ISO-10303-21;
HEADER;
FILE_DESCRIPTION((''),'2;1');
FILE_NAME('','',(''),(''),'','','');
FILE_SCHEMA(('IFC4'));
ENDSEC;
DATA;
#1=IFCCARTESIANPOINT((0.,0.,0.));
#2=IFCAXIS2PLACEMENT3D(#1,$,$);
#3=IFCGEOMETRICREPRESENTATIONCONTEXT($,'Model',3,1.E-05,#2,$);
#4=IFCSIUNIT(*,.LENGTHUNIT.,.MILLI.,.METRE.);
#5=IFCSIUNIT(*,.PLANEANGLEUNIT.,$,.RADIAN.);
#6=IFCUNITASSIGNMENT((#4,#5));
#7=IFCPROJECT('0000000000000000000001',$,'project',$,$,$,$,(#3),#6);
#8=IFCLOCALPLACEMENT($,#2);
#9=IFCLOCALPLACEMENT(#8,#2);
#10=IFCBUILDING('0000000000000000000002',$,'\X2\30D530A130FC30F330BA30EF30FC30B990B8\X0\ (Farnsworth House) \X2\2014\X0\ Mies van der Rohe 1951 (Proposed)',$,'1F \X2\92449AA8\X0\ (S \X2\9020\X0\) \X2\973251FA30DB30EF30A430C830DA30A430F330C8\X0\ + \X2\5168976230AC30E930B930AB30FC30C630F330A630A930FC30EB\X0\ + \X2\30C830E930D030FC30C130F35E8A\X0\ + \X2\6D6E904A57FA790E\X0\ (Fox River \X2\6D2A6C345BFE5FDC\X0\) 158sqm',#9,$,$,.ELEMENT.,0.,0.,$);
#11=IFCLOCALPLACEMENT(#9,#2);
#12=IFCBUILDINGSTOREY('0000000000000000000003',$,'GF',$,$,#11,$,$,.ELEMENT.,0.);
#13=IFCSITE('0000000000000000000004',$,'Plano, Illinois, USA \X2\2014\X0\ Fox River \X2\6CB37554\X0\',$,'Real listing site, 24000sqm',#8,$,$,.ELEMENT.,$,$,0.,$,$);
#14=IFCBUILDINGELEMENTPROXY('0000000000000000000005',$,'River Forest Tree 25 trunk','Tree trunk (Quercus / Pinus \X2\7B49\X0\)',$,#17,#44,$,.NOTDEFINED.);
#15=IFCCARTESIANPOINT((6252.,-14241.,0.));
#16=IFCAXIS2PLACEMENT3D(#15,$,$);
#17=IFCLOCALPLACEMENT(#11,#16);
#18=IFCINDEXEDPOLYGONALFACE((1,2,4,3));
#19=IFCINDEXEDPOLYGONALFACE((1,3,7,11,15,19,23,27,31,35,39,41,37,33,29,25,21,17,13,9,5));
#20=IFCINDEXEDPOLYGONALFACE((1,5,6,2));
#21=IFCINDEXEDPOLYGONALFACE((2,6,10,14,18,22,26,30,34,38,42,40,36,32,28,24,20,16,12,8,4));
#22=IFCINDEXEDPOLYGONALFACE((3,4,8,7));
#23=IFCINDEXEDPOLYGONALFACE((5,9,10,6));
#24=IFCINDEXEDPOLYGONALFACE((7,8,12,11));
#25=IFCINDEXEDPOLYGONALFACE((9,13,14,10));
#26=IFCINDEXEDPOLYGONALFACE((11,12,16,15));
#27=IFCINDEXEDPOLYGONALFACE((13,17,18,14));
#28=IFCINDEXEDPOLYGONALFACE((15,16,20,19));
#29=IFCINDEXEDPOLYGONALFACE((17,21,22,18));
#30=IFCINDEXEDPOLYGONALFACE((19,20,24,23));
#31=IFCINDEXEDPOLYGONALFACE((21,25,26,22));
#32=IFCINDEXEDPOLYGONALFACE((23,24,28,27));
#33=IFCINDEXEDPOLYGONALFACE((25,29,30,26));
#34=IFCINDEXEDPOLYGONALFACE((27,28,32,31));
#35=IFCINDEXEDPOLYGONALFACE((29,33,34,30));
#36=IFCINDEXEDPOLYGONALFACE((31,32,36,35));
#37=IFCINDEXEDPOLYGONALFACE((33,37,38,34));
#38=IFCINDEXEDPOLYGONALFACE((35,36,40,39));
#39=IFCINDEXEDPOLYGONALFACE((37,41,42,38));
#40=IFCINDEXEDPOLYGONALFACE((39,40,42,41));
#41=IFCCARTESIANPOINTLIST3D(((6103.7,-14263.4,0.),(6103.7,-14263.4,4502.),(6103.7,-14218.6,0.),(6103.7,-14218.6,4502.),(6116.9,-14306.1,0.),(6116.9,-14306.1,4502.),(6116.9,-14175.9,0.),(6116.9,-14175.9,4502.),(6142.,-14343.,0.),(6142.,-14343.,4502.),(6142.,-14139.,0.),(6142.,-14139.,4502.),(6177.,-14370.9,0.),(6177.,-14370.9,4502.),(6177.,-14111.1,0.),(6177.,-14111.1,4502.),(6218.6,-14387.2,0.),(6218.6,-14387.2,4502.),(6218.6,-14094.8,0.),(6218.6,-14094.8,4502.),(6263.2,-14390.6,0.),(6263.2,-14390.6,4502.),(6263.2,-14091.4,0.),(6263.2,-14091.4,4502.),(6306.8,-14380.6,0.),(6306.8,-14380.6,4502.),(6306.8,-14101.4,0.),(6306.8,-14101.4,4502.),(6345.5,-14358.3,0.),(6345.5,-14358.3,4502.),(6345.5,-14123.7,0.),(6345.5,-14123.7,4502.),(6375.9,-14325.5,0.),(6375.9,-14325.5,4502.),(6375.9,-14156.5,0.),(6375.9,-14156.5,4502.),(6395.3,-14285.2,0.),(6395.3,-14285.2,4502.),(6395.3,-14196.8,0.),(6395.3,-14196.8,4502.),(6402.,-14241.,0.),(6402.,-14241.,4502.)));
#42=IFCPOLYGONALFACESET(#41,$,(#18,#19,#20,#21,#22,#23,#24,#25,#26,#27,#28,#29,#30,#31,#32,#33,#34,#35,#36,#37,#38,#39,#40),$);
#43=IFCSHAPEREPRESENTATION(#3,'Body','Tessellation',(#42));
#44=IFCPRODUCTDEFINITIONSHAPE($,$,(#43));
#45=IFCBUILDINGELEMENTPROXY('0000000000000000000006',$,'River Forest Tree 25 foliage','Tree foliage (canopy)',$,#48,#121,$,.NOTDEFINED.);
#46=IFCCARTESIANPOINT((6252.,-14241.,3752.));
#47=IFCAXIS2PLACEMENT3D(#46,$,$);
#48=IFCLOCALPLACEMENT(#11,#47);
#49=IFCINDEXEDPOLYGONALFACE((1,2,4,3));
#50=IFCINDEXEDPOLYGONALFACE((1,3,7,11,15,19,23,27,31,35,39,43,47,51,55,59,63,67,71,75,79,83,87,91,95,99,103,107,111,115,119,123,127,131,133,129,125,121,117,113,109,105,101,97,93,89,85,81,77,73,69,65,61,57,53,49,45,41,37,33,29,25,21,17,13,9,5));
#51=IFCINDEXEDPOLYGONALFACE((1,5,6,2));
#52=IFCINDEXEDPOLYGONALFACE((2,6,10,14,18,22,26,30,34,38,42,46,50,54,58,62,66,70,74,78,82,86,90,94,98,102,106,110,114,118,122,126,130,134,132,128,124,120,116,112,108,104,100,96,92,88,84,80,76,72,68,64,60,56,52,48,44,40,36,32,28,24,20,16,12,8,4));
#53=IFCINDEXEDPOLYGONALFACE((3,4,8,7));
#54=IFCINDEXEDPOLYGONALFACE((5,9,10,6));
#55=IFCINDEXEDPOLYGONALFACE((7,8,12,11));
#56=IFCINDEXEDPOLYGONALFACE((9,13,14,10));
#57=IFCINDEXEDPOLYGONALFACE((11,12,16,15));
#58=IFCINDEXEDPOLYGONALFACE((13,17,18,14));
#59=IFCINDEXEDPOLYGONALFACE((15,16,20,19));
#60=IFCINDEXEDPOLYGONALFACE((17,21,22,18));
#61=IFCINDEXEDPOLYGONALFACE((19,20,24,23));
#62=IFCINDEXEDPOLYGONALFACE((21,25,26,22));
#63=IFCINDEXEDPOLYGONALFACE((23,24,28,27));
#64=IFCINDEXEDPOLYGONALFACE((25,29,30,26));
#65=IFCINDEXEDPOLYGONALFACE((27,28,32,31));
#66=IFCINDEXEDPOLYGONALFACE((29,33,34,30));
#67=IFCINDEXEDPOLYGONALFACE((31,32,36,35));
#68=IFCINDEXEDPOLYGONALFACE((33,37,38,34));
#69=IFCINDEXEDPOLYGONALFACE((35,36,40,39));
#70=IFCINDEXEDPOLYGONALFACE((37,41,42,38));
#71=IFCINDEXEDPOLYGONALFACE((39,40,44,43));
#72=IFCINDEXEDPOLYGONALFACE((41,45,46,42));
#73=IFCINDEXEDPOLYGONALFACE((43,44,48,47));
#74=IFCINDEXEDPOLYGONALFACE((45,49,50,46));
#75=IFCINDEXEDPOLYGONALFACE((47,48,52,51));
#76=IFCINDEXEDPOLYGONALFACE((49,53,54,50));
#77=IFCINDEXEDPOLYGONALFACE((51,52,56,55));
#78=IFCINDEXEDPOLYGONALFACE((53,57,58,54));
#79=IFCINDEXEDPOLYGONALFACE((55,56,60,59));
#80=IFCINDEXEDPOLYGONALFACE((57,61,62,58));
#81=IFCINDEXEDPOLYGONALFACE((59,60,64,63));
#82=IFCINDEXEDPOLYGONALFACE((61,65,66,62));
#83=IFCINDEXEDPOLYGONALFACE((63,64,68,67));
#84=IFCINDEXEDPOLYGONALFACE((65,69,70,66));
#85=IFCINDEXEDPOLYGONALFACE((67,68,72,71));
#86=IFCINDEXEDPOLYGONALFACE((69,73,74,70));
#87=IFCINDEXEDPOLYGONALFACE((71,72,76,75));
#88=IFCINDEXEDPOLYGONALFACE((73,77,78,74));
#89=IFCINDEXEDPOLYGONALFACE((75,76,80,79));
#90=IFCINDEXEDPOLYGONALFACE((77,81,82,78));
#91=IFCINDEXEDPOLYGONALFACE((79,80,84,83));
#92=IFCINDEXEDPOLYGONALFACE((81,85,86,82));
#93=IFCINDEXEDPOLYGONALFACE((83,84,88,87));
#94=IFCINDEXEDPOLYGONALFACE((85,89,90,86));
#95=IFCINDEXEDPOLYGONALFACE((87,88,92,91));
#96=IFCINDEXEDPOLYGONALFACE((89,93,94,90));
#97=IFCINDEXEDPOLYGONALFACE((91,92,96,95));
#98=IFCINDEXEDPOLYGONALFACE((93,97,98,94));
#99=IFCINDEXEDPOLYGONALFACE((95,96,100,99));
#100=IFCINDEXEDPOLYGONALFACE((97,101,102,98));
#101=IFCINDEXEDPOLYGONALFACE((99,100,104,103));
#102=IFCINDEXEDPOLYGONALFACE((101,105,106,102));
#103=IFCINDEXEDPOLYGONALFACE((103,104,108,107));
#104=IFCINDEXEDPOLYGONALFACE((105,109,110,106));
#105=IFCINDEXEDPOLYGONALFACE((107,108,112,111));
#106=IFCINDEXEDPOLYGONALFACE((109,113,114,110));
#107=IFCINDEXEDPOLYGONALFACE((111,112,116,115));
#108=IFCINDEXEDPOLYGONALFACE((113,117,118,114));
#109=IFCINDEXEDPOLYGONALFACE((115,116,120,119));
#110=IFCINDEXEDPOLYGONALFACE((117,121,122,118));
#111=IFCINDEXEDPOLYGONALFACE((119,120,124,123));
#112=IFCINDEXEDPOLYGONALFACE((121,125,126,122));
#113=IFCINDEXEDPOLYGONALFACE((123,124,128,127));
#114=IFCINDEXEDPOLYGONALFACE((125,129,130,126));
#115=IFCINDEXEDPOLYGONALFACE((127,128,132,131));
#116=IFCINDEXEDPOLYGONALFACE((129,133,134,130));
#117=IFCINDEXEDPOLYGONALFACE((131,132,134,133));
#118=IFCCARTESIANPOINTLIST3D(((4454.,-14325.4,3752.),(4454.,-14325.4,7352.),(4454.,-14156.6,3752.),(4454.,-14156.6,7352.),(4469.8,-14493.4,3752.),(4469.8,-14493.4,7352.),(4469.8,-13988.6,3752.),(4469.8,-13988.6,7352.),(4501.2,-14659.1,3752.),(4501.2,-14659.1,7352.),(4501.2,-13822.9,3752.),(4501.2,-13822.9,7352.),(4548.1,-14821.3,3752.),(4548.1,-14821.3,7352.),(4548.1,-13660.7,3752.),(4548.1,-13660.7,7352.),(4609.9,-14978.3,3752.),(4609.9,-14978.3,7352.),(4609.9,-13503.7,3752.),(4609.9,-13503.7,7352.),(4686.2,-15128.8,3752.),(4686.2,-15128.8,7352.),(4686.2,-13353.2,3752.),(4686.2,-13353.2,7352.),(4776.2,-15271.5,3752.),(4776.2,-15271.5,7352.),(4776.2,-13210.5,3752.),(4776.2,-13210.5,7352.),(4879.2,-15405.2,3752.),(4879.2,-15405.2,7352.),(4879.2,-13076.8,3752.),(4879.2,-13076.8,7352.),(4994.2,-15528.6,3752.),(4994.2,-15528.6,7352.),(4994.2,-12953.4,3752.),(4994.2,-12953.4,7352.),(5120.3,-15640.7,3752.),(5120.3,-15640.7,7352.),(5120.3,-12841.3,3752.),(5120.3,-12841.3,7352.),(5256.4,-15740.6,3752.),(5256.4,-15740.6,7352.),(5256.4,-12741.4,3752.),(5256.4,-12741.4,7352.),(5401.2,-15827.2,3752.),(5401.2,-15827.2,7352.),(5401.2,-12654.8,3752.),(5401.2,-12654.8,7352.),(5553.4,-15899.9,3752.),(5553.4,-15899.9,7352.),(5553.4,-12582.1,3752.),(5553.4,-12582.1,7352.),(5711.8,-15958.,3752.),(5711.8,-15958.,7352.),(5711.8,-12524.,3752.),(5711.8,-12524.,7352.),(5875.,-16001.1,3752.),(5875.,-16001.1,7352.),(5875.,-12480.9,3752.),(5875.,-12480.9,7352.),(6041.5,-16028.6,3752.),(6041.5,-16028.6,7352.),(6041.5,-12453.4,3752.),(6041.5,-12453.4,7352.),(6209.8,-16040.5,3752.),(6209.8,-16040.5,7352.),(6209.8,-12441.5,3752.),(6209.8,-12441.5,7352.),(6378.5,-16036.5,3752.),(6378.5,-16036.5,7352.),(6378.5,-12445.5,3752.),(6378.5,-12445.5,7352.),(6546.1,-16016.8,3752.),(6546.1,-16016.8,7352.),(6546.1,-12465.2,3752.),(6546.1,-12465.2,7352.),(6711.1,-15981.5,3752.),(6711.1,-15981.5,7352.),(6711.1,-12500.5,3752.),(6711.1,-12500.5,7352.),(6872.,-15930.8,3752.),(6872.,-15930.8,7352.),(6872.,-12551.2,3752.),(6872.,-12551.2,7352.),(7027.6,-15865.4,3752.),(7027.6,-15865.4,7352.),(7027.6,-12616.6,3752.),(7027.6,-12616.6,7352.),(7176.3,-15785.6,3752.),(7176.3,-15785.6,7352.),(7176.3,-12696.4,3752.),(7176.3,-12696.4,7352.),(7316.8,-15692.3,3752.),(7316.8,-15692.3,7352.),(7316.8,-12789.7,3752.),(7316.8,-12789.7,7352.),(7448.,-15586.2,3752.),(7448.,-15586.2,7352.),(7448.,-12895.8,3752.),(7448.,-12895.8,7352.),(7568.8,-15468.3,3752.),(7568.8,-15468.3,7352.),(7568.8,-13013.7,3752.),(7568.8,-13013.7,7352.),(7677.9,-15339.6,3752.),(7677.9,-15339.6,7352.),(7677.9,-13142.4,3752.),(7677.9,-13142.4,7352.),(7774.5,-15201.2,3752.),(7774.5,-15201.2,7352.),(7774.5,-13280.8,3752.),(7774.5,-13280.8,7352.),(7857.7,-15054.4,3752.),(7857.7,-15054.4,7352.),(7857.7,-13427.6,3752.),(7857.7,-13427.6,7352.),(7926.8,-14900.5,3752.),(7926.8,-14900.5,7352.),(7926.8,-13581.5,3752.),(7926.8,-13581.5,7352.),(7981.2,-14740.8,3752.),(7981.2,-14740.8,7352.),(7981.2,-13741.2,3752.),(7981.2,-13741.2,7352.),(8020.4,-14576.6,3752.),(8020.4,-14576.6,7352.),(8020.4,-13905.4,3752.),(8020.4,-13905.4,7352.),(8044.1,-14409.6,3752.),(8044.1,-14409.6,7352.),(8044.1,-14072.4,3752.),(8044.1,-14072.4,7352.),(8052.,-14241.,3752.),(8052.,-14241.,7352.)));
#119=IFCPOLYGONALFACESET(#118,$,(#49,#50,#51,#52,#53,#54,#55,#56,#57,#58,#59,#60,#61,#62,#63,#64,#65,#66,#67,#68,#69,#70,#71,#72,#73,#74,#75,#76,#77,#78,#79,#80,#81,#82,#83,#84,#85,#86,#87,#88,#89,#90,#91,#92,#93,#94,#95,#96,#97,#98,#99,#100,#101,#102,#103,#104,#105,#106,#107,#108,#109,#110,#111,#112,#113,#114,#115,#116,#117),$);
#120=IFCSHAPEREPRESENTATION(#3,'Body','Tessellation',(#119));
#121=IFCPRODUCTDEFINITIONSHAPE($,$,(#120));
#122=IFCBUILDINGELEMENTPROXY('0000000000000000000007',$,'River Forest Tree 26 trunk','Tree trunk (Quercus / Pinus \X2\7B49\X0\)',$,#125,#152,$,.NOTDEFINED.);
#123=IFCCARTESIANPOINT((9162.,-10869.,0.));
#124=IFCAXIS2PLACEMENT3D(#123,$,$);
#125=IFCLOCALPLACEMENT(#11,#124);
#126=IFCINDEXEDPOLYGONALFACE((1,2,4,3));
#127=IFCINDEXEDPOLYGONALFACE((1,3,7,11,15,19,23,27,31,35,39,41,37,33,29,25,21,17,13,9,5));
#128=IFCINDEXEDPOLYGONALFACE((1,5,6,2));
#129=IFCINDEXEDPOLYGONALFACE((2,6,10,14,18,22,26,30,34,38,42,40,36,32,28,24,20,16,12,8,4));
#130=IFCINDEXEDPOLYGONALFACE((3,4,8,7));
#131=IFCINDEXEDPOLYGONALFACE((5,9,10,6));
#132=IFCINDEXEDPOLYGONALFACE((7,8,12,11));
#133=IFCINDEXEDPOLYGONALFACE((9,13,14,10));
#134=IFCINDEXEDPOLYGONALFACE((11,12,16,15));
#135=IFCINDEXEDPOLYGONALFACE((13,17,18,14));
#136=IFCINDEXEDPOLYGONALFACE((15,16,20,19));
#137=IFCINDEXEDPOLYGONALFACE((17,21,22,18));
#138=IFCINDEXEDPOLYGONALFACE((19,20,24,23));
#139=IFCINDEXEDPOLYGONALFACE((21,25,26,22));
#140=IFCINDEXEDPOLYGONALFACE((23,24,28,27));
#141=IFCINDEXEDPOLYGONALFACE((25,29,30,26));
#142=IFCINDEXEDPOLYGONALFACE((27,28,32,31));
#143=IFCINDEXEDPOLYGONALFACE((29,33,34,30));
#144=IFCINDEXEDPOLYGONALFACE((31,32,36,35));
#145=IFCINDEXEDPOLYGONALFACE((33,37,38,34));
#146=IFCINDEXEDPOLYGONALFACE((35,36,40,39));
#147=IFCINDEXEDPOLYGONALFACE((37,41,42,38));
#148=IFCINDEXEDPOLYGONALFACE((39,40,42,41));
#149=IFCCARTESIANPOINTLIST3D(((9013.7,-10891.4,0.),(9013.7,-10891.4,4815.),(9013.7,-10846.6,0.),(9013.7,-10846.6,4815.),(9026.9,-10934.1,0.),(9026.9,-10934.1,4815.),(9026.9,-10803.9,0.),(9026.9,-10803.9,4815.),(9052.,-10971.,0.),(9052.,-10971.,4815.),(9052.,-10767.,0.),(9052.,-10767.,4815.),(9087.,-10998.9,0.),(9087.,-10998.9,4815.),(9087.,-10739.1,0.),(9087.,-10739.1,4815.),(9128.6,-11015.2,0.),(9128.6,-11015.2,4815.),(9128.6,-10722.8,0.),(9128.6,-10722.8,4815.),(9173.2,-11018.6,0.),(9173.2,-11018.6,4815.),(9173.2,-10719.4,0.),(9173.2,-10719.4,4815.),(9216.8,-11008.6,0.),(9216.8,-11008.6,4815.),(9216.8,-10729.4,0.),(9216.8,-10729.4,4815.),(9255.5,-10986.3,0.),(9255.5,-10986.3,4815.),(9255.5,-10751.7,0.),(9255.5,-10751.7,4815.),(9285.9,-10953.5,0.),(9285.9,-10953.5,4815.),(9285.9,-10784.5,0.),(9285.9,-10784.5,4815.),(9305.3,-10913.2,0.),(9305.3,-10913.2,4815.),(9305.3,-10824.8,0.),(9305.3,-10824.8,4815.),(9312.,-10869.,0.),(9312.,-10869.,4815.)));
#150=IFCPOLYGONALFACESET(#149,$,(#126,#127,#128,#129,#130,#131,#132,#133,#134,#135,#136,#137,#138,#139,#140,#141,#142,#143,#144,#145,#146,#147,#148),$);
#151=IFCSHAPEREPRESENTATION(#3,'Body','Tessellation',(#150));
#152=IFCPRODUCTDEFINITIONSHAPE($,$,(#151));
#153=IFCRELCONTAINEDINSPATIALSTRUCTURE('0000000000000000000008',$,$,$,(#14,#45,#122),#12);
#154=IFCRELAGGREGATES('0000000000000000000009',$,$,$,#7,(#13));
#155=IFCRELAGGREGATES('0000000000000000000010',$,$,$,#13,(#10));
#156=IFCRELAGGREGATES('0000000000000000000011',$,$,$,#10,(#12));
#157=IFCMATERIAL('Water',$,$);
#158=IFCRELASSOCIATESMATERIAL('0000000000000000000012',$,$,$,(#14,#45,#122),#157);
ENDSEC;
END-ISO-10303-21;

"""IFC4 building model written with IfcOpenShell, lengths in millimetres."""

from ifc_helpers import new_model, si_unit, frame, origin, origin_2d, place, context, project, spatial, circle, extrude, material, element, save


model = new_model("IFC4")

# Units and contexts
model_context = context("Model", 3, precision=1e-05, world=origin())
ifc_project = project(units=[si_unit("LENGTHUNIT", "METRE", prefix="MILLI"), si_unit("PLANEANGLEUNIT", "RADIAN")], contexts=[model_context])

# Site, building, storey
site_placement = place(None, origin())
site = spatial("IfcSite", under=ifc_project, at=site_placement, Name="Plano, Illinois, USA — Fox River 河畔", ObjectType="Real listing site, 24000sqm", CompositionType="ELEMENT", RefElevation=0.0)
building_placement = place(site_placement, origin())
building = spatial("IfcBuilding", under=site, at=building_placement, Name="ファーンズワース邸 (Farnsworth House) — Mies van der Rohe 1951 (Proposed)", ObjectType="1F 鉄骨 (S 造) 露出ホワイトペイント + 全面ガラスカーテンウォール + トラバーチン床 + 浮遊基礎 (Fox River 洪水対応) 158sqm", CompositionType="ELEMENT", ElevationOfRefHeight=0.0, ElevationOfTerrain=0.0)
storey_placement = place(building_placement, origin())
storey = spatial("IfcBuildingStorey", under=building, at=storey_placement, Name="GF", CompositionType="ELEMENT", Elevation=0.0)

# Building element proxies
ifc_material_1 = material(Name="Water")
proxy_1_placement = place(storey_placement, frame((6252.0, -14241.0, 0.0)))
element("IfcBuildingElementProxy", 1, at=proxy_1_placement, inside=storey, material=ifc_material_1, Name="River Forest Tree 25 trunk", Description="Tree trunk (Quercus / Pinus 等)", PredefinedType="NOTDEFINED", context=model_context, shape_type="SweptSolid", body=[
    extrude(circle(Radius=150.0, at=origin_2d()), frame((6252.0, -14241.0, 0.0)), (0.0, 0.0, 1.0), 4502.0),
])
proxy_2_placement = place(storey_placement, frame((6252.0, -14241.0, 3752.0)))
element("IfcBuildingElementProxy", 2, at=proxy_2_placement, inside=storey, material=ifc_material_1, Name="River Forest Tree 25 foliage", Description="Tree foliage (canopy)", PredefinedType="NOTDEFINED", context=model_context, shape_type="SweptSolid", body=[
    extrude(circle(Radius=1800.0, at=origin_2d()), frame((6252.0, -14241.0, 3752.0)), (0.0, 0.0, 1.0), 3600.0),
])
proxy_3_placement = place(storey_placement, frame((9162.0, -10869.0, 0.0)))
element("IfcBuildingElementProxy", 3, at=proxy_3_placement, inside=storey, material=ifc_material_1, Name="River Forest Tree 26 trunk", Description="Tree trunk (Quercus / Pinus 等)", PredefinedType="NOTDEFINED", context=model_context, shape_type="SweptSolid", body=[
    extrude(circle(Radius=150.0, at=origin_2d()), frame((9162.0, -10869.0, 0.0)), (0.0, 0.0, 1.0), 4815.0),
])

save(model, "model.ifc")
